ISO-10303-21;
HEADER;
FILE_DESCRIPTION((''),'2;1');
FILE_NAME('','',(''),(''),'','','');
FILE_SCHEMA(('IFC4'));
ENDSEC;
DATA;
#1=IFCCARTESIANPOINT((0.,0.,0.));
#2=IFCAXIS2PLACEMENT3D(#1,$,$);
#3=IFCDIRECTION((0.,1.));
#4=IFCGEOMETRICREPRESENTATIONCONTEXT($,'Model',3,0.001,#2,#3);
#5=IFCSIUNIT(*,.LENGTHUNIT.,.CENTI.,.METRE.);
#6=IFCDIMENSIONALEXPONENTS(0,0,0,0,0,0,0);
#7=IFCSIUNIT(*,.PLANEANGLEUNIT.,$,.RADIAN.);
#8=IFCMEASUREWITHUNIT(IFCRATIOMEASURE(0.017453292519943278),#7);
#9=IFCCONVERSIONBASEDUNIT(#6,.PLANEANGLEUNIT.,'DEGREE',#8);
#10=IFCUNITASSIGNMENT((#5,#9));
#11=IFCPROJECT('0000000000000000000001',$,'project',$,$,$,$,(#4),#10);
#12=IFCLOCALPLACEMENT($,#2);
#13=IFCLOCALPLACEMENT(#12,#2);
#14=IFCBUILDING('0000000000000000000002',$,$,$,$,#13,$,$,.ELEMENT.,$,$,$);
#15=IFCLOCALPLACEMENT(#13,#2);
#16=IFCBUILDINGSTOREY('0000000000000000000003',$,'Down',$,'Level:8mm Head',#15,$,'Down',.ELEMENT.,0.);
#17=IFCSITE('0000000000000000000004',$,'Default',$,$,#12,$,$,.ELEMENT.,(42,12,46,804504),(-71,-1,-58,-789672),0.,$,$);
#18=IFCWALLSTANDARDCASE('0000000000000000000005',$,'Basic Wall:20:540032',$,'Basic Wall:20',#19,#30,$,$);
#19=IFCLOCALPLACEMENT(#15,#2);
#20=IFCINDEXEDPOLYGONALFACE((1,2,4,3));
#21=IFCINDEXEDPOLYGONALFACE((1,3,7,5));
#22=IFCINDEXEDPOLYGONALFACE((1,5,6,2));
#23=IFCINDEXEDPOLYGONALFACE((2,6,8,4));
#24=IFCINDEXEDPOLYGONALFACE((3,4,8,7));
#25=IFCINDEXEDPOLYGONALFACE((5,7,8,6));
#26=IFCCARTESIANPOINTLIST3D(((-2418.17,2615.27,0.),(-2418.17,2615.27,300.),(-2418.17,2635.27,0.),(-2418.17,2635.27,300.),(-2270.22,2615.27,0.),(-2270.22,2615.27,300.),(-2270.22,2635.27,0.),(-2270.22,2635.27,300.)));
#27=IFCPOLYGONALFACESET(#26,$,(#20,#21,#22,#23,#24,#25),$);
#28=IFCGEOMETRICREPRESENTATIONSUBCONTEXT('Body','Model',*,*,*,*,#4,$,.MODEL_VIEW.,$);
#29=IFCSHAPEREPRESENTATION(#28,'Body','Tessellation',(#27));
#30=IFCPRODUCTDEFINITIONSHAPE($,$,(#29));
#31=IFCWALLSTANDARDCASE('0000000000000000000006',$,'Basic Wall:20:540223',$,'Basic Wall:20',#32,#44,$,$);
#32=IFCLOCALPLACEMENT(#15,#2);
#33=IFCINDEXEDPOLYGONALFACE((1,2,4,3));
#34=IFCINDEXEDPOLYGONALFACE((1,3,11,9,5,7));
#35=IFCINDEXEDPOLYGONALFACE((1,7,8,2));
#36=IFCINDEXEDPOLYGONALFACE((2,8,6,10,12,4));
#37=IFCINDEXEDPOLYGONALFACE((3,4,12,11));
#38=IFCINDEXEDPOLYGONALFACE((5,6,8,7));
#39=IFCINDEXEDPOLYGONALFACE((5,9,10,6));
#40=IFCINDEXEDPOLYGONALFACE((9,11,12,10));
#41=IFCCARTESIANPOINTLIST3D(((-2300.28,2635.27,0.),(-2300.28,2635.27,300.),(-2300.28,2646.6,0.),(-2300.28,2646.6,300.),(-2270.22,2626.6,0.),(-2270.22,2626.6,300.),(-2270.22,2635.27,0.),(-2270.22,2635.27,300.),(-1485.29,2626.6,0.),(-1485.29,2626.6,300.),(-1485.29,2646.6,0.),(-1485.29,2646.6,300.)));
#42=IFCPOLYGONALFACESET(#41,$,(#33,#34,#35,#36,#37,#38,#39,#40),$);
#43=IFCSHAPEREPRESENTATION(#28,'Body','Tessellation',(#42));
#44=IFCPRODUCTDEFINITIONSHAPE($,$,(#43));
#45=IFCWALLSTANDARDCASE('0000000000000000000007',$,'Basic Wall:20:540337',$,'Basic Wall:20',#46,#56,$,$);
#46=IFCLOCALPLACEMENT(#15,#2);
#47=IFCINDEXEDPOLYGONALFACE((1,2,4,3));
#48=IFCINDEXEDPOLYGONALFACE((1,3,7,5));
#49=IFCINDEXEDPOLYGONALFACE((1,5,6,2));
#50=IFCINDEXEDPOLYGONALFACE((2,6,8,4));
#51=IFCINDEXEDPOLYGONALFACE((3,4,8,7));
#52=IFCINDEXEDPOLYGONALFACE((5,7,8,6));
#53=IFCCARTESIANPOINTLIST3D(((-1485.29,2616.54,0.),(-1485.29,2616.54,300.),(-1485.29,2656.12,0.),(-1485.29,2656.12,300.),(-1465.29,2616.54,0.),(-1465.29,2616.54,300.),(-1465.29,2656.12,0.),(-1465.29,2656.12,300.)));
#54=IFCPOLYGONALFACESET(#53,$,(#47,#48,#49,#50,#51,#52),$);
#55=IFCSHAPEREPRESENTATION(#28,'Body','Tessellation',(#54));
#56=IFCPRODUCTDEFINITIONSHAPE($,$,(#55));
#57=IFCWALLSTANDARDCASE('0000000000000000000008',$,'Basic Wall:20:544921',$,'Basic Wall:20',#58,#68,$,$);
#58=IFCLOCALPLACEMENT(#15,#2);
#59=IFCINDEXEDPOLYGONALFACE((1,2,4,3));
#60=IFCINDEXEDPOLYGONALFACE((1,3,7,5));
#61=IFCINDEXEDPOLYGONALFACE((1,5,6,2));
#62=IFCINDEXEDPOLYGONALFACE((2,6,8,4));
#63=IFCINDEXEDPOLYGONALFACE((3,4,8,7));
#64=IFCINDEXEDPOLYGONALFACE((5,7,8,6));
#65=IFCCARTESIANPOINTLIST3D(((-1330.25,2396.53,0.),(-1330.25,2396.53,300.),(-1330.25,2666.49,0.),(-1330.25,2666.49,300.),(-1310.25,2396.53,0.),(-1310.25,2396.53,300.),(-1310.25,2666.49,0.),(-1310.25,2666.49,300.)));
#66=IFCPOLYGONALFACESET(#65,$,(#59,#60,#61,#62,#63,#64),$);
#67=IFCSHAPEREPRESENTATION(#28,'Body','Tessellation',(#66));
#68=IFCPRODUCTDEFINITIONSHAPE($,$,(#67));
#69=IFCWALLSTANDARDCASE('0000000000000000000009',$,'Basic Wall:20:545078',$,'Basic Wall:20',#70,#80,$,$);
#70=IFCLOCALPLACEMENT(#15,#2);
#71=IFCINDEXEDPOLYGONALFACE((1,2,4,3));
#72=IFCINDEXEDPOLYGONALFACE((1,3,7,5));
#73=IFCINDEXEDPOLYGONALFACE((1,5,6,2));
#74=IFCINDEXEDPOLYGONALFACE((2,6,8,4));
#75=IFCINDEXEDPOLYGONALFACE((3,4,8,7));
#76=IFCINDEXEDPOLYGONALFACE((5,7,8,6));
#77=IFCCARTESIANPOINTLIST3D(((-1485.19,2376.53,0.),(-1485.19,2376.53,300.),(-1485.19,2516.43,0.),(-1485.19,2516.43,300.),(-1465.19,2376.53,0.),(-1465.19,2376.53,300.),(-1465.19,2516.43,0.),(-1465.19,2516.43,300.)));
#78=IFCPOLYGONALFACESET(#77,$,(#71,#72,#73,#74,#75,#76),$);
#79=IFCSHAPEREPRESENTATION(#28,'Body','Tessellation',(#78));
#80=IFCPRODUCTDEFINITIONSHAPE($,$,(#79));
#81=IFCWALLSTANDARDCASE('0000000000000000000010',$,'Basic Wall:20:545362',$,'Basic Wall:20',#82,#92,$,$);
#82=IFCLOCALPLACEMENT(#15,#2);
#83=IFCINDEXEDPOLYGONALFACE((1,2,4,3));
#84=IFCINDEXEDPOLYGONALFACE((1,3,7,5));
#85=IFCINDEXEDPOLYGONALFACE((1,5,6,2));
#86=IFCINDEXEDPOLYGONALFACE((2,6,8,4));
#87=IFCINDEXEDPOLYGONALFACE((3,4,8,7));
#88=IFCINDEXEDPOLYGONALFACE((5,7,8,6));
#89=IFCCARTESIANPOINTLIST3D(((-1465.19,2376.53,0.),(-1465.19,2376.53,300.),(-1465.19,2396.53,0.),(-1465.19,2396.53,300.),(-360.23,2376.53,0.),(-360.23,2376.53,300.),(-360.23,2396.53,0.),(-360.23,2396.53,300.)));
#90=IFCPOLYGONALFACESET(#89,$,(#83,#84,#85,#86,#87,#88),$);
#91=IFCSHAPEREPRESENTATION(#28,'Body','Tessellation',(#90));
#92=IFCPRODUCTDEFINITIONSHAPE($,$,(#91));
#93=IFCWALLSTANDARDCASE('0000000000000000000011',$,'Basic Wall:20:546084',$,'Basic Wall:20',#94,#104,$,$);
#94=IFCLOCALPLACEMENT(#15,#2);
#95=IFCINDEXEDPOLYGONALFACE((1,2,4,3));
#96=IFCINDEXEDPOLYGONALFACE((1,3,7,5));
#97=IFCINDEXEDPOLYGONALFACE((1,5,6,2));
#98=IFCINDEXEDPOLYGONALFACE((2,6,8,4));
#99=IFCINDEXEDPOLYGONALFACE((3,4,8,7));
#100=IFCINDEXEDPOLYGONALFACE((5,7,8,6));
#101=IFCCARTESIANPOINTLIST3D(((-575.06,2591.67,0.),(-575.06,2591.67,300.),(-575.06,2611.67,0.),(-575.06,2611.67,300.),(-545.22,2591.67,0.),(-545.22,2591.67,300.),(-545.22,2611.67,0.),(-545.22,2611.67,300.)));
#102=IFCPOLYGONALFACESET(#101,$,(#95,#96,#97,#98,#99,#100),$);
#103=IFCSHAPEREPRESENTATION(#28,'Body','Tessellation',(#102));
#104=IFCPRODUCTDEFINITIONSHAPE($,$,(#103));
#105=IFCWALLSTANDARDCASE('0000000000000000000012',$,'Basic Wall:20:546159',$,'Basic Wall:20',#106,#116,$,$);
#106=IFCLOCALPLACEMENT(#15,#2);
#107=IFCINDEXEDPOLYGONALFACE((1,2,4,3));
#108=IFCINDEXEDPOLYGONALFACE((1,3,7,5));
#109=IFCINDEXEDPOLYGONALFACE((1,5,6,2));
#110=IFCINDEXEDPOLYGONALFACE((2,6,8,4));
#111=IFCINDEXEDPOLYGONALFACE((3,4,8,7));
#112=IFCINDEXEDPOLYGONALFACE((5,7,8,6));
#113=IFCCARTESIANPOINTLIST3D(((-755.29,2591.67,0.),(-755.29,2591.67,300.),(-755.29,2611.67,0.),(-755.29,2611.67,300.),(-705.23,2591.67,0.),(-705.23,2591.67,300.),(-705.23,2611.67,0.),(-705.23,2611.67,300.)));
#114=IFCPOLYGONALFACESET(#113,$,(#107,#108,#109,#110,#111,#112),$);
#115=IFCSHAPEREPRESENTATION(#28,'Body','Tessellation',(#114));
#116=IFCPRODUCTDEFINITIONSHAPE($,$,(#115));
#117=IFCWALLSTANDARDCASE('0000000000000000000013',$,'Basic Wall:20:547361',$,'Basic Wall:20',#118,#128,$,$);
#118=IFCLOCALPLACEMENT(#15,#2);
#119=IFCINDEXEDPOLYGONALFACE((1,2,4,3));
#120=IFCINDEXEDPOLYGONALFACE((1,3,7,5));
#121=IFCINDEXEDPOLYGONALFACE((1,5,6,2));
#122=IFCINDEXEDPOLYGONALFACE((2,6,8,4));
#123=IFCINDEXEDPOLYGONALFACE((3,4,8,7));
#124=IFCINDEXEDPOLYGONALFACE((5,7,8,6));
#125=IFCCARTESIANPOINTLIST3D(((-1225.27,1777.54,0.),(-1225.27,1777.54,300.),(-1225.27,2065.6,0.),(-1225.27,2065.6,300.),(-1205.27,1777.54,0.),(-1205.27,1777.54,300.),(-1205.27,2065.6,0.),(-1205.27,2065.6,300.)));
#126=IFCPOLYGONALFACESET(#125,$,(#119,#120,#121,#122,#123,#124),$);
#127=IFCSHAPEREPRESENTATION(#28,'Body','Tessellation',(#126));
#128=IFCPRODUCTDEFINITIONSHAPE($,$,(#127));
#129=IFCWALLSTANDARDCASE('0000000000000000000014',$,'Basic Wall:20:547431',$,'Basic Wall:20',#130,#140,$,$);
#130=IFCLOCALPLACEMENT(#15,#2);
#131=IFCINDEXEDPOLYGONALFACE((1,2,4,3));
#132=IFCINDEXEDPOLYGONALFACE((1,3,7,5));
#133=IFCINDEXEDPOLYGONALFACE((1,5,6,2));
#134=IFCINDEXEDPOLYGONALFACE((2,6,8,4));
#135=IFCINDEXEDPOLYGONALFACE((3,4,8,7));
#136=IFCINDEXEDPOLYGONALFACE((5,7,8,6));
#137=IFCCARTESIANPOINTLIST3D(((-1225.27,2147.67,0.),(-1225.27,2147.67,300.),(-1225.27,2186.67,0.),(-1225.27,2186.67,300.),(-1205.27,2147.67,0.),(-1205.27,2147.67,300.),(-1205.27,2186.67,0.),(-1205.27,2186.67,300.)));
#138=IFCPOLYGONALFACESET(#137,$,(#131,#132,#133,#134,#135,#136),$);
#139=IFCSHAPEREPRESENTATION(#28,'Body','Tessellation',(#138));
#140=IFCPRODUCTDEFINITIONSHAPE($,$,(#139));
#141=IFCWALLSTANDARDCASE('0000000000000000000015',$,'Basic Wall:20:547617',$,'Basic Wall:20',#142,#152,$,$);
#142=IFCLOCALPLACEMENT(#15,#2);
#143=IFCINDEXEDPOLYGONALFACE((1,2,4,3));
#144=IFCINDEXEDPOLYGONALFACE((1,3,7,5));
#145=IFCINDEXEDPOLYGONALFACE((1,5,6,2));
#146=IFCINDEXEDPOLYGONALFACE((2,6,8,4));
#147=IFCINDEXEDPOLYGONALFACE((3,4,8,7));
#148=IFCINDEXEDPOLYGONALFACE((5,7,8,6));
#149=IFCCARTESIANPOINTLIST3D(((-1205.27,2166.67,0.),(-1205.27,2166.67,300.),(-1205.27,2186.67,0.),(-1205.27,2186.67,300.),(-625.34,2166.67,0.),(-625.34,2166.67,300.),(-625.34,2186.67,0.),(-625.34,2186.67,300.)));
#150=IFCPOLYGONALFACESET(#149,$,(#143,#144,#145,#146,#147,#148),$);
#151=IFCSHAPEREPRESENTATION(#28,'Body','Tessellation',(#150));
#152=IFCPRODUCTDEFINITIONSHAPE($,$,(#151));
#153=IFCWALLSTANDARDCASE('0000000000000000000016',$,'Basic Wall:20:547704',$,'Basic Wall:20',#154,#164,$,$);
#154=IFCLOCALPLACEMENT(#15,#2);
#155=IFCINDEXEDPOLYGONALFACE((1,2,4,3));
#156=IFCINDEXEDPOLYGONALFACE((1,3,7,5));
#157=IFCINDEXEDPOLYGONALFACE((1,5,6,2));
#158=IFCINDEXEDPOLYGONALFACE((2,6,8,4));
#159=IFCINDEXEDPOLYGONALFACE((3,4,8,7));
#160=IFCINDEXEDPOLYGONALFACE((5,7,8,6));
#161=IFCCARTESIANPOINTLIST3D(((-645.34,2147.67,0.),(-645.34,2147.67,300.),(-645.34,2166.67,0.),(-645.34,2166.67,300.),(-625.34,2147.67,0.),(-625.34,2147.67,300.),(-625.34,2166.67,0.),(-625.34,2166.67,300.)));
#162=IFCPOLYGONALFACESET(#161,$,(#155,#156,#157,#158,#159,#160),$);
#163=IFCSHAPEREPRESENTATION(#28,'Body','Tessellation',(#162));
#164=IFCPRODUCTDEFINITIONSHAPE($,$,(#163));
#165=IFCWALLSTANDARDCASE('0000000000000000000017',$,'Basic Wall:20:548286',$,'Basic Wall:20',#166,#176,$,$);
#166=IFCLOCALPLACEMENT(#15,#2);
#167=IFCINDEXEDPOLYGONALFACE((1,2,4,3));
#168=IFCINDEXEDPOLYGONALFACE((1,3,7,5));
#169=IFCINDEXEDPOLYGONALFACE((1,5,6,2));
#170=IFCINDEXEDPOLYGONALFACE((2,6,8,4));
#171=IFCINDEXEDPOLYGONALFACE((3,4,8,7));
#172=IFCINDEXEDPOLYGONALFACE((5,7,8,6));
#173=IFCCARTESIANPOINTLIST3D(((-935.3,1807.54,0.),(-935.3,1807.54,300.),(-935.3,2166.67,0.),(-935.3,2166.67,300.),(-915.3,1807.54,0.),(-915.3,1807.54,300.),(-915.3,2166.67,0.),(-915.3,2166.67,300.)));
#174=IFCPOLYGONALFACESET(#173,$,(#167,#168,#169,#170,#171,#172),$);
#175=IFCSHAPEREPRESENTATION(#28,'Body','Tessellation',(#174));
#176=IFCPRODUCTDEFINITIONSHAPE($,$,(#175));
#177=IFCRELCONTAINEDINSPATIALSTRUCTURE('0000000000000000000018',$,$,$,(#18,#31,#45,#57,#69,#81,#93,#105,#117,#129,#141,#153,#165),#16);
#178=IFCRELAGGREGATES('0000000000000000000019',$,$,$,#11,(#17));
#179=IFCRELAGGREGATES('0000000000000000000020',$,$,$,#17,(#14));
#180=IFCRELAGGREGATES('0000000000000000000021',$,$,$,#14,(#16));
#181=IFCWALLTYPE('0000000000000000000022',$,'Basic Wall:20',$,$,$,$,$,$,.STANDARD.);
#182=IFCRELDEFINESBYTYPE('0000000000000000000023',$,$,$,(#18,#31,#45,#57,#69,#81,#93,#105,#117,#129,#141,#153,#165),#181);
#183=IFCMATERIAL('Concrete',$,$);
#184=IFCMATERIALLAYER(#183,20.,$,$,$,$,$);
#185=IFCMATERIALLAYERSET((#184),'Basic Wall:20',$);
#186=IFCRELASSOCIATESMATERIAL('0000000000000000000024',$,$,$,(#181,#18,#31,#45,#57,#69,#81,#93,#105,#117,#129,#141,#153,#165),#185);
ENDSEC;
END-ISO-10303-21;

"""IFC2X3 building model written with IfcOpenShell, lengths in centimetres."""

from ifc_helpers import new_model, entity, si_unit, converted_unit, direction, frame, frame_2d, origin, place, context, subcontext, project, spatial, polyline, rectangle, extrude, clip, bounded_halfspace, material, layer, layer_set, layer_usage, type_object, element, save


model = new_model("IFC2X3")

# Units and contexts
model_context = context("Model", 3, precision=0.001, world=origin(), true_north=direction((0.0, 1.0)))
body_context = subcontext(model_context, "Body", "Model", "MODEL_VIEW")
ifc_project = project(units=[si_unit("LENGTHUNIT", "METRE", prefix="CENTI"), converted_unit("PLANEANGLEUNIT", "DEGREE", entity("IfcRatioMeasure", 0.017453292519943278), si_unit("PLANEANGLEUNIT", "RADIAN"), dimensions=[0, 0, 0, 0, 0, 0, 0])], contexts=[model_context])

# Site, building, storey
site_placement = place(None, origin())
site = spatial("IfcSite", under=ifc_project, at=site_placement, Name="Default", CompositionType="ELEMENT", RefLatitude=(42, 12, 46, 804504), RefLongitude=(-71, -1, -58, -789672), RefElevation=0.0)
building_placement = place(site_placement, origin())
building = spatial("IfcBuilding", under=site, at=building_placement, CompositionType="ELEMENT")
storey_placement = place(building_placement, origin())
storey = spatial("IfcBuildingStorey", under=building, at=storey_placement, Name="Down", ObjectType="Level:8mm Head", LongName="Down", CompositionType="ELEMENT", Elevation=0.0)

# Walls
ifc_material = material(Name="Concrete")
ifc_layer_1 = layer(ifc_material, 20.0)
ifc_layer_set_1 = layer_set([ifc_layer_1], Name="Basic Wall:20")
ifc_layer_usage_1 = layer_usage(ifc_layer_set_1, "AXIS2", "POSITIVE", -10.0)
wall_type_1 = type_object("IfcWallType", Name="Basic Wall:20", PredefinedType="STANDARD", material=ifc_layer_set_1)
wall_1_placement = place(storey_placement, frame((-2418.17, 2625.27, 0.0)))
element("IfcWallStandardCase", 1, at=wall_1_placement, inside=storey, type_object=wall_type_1, material=ifc_layer_usage_1, Name="Basic Wall:20:540032", ObjectType="Basic Wall:20", context=body_context, shape_type="SweptSolid", body=[
    extrude(rectangle(XDim=147.95, YDim=20.0, at=frame_2d((73.97, 0.0), x_axis=(-1.0, 0.0))), origin(), (0.0, 0.0, 1.0), 300.0),
])
ifc_layer_usage_2 = layer_usage(ifc_layer_set_1, "AXIS2", "NEGATIVE", 10.0)
wall_2_placement = place(storey_placement, frame((-2300.28, 2636.6, 0.0)))
element("IfcWallStandardCase", 2, at=wall_2_placement, inside=storey, type_object=wall_type_1, material=ifc_layer_usage_2, Name="Basic Wall:20:540223", ObjectType="Basic Wall:20", context=body_context, shape_type="Clipping", body=[
    clip(clip(extrude(rectangle(XDim=814.99, YDim=20.0, at=frame_2d((407.49, 0.0), x_axis=(-1.0, 0.0))), origin(), (0.0, 0.0, 1.0), 300.0), bounded_halfspace(frame((30.06, -1.32, 0.0), z_axis=(0.0, 1.0, 0.0), x_axis=(-1.0, 0.0, 0.0)), True, frame((30.06, -1.32, 0.0), z_axis=(0.0, 1.0, 0.0), x_axis=(-1.0, 0.0, 0.0)), polyline([(0.0, 0.0), (30.06, 0.0), (30.06, 280.0), (30.06, 300.0), (0.0, 300.0), (0.0, 0.0)]))), bounded_halfspace(frame((30.06, -1.32, 300.0), z_axis=(1.0, 0.0, 0.0), x_axis=(0.0, 1.0, 0.0)), True, frame((30.06, -1.32, 300.0), z_axis=(1.0, 0.0, 0.0), x_axis=(0.0, 1.0, 0.0)), polyline([(0.0, 0.0), (-8.68, 0.0), (-8.68, -20.0), (-8.68, -300.0), (0.0, -300.0), (0.0, 0.0)]))),
])
ifc_layer_usage_3 = layer_usage(ifc_layer_set_1, "AXIS2", "POSITIVE", -10.0)
wall_3_placement = place(storey_placement, frame((-1475.29, 2616.54, 0.0), z_axis=(0.0, 0.0, 1.0), x_axis=(0.0, 1.0, 0.0)))
element("IfcWallStandardCase", 3, at=wall_3_placement, inside=storey, type_object=wall_type_1, material=ifc_layer_usage_3, Name="Basic Wall:20:540337", ObjectType="Basic Wall:20", context=body_context, shape_type="SweptSolid", body=[
    extrude(rectangle(XDim=39.58, YDim=20.0, at=frame_2d((19.79, 0.0), x_axis=(-1.0, 0.0))), origin(), (0.0, 0.0, 1.0), 300.0),
])
ifc_layer_usage_4 = layer_usage(ifc_layer_set_1, "AXIS2", "POSITIVE", -10.0)
wall_4_placement = place(storey_placement, frame((-1320.25, 2666.49, 0.0), z_axis=(0.0, 0.0, 1.0), x_axis=(0.0, -1.0, 0.0)))
element("IfcWallStandardCase", 4, at=wall_4_placement, inside=storey, type_object=wall_type_1, material=ifc_layer_usage_4, Name="Basic Wall:20:544921", ObjectType="Basic Wall:20", context=body_context, shape_type="SweptSolid", body=[
    extrude(rectangle(XDim=269.97, YDim=20.0, at=frame_2d((134.98, 0.0), x_axis=(-1.0, 0.0))), origin(), (0.0, 0.0, 1.0), 300.0),
])
ifc_layer_usage_5 = layer_usage(ifc_layer_set_1, "AXIS2", "POSITIVE", -10.0)
wall_5_placement = place(storey_placement, frame((-1475.19, 2516.43, 0.0), z_axis=(0.0, 0.0, 1.0), x_axis=(0.0, -1.0, 0.0)))
element("IfcWallStandardCase", 5, at=wall_5_placement, inside=storey, type_object=wall_type_1, material=ifc_layer_usage_5, Name="Basic Wall:20:545078", ObjectType="Basic Wall:20", context=body_context, shape_type="SweptSolid", body=[
    extrude(rectangle(XDim=139.91, YDim=20.0, at=frame_2d((69.95, 0.0), x_axis=(-1.0, 0.0))), origin(), (0.0, 0.0, 1.0), 300.0),
])
ifc_layer_usage_6 = layer_usage(ifc_layer_set_1, "AXIS2", "POSITIVE", -10.0)
wall_6_placement = place(storey_placement, frame((-1465.19, 2386.53, 0.0)))
element("IfcWallStandardCase", 6, at=wall_6_placement, inside=storey, type_object=wall_type_1, material=ifc_layer_usage_6, Name="Basic Wall:20:545362", ObjectType="Basic Wall:20", context=body_context, shape_type="SweptSolid", body=[
    extrude(rectangle(XDim=1104.96, YDim=20.0, at=frame_2d((552.48, 0.0), x_axis=(-1.0, 0.0))), origin(), (0.0, 0.0, 1.0), 300.0),
])
ifc_layer_usage_7 = layer_usage(ifc_layer_set_1, "AXIS2", "POSITIVE", -10.0)
wall_7_placement = place(storey_placement, frame((-545.22, 2601.67, 0.0), z_axis=(0.0, 0.0, 1.0), x_axis=(-1.0, 0.0, 0.0)))
element("IfcWallStandardCase", 7, at=wall_7_placement, inside=storey, type_object=wall_type_1, material=ifc_layer_usage_7, Name="Basic Wall:20:546084", ObjectType="Basic Wall:20", context=body_context, shape_type="SweptSolid", body=[
    extrude(rectangle(XDim=29.84, YDim=20.0, at=frame_2d((14.92, 0.0), x_axis=(-1.0, 0.0))), origin(), (0.0, 0.0, 1.0), 300.0),
])
ifc_layer_usage_8 = layer_usage(ifc_layer_set_1, "AXIS2", "POSITIVE", -10.0)
wall_8_placement = place(storey_placement, frame((-705.23, 2601.67, 0.0), z_axis=(0.0, 0.0, 1.0), x_axis=(-1.0, 0.0, 0.0)))
element("IfcWallStandardCase", 8, at=wall_8_placement, inside=storey, type_object=wall_type_1, material=ifc_layer_usage_8, Name="Basic Wall:20:546159", ObjectType="Basic Wall:20", context=body_context, shape_type="SweptSolid", body=[
    extrude(rectangle(XDim=50.05, YDim=20.0, at=frame_2d((25.03, 0.0), x_axis=(-1.0, 0.0))), origin(), (0.0, 0.0, 1.0), 300.0),
])
ifc_layer_usage_9 = layer_usage(ifc_layer_set_1, "AXIS2", "NEGATIVE", 10.0)
wall_9_placement = place(storey_placement, frame((-1215.27, 1777.54, 0.0), z_axis=(0.0, 0.0, 1.0), x_axis=(0.0, 1.0, 0.0)))
element("IfcWallStandardCase", 9, at=wall_9_placement, inside=storey, type_object=wall_type_1, material=ifc_layer_usage_9, Name="Basic Wall:20:547361", ObjectType="Basic Wall:20", context=body_context, shape_type="SweptSolid", body=[
    extrude(rectangle(XDim=288.07, YDim=20.0, at=frame_2d((144.03, 0.0), x_axis=(-1.0, 0.0))), origin(), (0.0, 0.0, 1.0), 300.0),
])
ifc_layer_usage_10 = layer_usage(ifc_layer_set_1, "AXIS2", "NEGATIVE", 10.0)
wall_10_placement = place(storey_placement, frame((-1215.27, 2147.67, 0.0), z_axis=(0.0, 0.0, 1.0), x_axis=(0.0, 1.0, 0.0)))
element("IfcWallStandardCase", 10, at=wall_10_placement, inside=storey, type_object=wall_type_1, material=ifc_layer_usage_10, Name="Basic Wall:20:547431", ObjectType="Basic Wall:20", context=body_context, shape_type="SweptSolid", body=[
    extrude(rectangle(XDim=39.0, YDim=20.0, at=frame_2d((19.5, 0.0), x_axis=(-1.0, 0.0))), origin(), (0.0, 0.0, 1.0), 300.0),
])
ifc_layer_usage_11 = layer_usage(ifc_layer_set_1, "AXIS2", "NEGATIVE", 10.0)
wall_11_placement = place(storey_placement, frame((-1205.27, 2176.67, 0.0)))
element("IfcWallStandardCase", 11, at=wall_11_placement, inside=storey, type_object=wall_type_1, material=ifc_layer_usage_11, Name="Basic Wall:20:547617", ObjectType="Basic Wall:20", context=body_context, shape_type="SweptSolid", body=[
    extrude(rectangle(XDim=579.94, YDim=20.0, at=frame_2d((289.97, 0.0), x_axis=(-1.0, 0.0))), origin(), (0.0, 0.0, 1.0), 300.0),
])
ifc_layer_usage_12 = layer_usage(ifc_layer_set_1, "AXIS2", "NEGATIVE", 10.0)
wall_12_placement = place(storey_placement, frame((-635.34, 2166.67, 0.0), z_axis=(0.0, 0.0, 1.0), x_axis=(0.0, -1.0, 0.0)))
element("IfcWallStandardCase", 12, at=wall_12_placement, inside=storey, type_object=wall_type_1, material=ifc_layer_usage_12, Name="Basic Wall:20:547704", ObjectType="Basic Wall:20", context=body_context, shape_type="SweptSolid", body=[
    extrude(rectangle(XDim=19.0, YDim=20.0, at=frame_2d((9.5, 0.0), x_axis=(-1.0, 0.0))), origin(), (0.0, 0.0, 1.0), 300.0),
])
ifc_layer_usage_13 = layer_usage(ifc_layer_set_1, "AXIS2", "POSITIVE", -10.0)
wall_13_placement = place(storey_placement, frame((-925.3, 2166.67, 0.0), z_axis=(0.0, 0.0, 1.0), x_axis=(0.0, -1.0, 0.0)))
element("IfcWallStandardCase", 13, at=wall_13_placement, inside=storey, type_object=wall_type_1, material=ifc_layer_usage_13, Name="Basic Wall:20:548286", ObjectType="Basic Wall:20", context=body_context, shape_type="SweptSolid", body=[
    extrude(rectangle(XDim=359.13, YDim=20.0, at=frame_2d((179.57, 0.0), x_axis=(-1.0, 0.0))), origin(), (0.0, 0.0, 1.0), 300.0),
])

save(model, "model.ifc")
